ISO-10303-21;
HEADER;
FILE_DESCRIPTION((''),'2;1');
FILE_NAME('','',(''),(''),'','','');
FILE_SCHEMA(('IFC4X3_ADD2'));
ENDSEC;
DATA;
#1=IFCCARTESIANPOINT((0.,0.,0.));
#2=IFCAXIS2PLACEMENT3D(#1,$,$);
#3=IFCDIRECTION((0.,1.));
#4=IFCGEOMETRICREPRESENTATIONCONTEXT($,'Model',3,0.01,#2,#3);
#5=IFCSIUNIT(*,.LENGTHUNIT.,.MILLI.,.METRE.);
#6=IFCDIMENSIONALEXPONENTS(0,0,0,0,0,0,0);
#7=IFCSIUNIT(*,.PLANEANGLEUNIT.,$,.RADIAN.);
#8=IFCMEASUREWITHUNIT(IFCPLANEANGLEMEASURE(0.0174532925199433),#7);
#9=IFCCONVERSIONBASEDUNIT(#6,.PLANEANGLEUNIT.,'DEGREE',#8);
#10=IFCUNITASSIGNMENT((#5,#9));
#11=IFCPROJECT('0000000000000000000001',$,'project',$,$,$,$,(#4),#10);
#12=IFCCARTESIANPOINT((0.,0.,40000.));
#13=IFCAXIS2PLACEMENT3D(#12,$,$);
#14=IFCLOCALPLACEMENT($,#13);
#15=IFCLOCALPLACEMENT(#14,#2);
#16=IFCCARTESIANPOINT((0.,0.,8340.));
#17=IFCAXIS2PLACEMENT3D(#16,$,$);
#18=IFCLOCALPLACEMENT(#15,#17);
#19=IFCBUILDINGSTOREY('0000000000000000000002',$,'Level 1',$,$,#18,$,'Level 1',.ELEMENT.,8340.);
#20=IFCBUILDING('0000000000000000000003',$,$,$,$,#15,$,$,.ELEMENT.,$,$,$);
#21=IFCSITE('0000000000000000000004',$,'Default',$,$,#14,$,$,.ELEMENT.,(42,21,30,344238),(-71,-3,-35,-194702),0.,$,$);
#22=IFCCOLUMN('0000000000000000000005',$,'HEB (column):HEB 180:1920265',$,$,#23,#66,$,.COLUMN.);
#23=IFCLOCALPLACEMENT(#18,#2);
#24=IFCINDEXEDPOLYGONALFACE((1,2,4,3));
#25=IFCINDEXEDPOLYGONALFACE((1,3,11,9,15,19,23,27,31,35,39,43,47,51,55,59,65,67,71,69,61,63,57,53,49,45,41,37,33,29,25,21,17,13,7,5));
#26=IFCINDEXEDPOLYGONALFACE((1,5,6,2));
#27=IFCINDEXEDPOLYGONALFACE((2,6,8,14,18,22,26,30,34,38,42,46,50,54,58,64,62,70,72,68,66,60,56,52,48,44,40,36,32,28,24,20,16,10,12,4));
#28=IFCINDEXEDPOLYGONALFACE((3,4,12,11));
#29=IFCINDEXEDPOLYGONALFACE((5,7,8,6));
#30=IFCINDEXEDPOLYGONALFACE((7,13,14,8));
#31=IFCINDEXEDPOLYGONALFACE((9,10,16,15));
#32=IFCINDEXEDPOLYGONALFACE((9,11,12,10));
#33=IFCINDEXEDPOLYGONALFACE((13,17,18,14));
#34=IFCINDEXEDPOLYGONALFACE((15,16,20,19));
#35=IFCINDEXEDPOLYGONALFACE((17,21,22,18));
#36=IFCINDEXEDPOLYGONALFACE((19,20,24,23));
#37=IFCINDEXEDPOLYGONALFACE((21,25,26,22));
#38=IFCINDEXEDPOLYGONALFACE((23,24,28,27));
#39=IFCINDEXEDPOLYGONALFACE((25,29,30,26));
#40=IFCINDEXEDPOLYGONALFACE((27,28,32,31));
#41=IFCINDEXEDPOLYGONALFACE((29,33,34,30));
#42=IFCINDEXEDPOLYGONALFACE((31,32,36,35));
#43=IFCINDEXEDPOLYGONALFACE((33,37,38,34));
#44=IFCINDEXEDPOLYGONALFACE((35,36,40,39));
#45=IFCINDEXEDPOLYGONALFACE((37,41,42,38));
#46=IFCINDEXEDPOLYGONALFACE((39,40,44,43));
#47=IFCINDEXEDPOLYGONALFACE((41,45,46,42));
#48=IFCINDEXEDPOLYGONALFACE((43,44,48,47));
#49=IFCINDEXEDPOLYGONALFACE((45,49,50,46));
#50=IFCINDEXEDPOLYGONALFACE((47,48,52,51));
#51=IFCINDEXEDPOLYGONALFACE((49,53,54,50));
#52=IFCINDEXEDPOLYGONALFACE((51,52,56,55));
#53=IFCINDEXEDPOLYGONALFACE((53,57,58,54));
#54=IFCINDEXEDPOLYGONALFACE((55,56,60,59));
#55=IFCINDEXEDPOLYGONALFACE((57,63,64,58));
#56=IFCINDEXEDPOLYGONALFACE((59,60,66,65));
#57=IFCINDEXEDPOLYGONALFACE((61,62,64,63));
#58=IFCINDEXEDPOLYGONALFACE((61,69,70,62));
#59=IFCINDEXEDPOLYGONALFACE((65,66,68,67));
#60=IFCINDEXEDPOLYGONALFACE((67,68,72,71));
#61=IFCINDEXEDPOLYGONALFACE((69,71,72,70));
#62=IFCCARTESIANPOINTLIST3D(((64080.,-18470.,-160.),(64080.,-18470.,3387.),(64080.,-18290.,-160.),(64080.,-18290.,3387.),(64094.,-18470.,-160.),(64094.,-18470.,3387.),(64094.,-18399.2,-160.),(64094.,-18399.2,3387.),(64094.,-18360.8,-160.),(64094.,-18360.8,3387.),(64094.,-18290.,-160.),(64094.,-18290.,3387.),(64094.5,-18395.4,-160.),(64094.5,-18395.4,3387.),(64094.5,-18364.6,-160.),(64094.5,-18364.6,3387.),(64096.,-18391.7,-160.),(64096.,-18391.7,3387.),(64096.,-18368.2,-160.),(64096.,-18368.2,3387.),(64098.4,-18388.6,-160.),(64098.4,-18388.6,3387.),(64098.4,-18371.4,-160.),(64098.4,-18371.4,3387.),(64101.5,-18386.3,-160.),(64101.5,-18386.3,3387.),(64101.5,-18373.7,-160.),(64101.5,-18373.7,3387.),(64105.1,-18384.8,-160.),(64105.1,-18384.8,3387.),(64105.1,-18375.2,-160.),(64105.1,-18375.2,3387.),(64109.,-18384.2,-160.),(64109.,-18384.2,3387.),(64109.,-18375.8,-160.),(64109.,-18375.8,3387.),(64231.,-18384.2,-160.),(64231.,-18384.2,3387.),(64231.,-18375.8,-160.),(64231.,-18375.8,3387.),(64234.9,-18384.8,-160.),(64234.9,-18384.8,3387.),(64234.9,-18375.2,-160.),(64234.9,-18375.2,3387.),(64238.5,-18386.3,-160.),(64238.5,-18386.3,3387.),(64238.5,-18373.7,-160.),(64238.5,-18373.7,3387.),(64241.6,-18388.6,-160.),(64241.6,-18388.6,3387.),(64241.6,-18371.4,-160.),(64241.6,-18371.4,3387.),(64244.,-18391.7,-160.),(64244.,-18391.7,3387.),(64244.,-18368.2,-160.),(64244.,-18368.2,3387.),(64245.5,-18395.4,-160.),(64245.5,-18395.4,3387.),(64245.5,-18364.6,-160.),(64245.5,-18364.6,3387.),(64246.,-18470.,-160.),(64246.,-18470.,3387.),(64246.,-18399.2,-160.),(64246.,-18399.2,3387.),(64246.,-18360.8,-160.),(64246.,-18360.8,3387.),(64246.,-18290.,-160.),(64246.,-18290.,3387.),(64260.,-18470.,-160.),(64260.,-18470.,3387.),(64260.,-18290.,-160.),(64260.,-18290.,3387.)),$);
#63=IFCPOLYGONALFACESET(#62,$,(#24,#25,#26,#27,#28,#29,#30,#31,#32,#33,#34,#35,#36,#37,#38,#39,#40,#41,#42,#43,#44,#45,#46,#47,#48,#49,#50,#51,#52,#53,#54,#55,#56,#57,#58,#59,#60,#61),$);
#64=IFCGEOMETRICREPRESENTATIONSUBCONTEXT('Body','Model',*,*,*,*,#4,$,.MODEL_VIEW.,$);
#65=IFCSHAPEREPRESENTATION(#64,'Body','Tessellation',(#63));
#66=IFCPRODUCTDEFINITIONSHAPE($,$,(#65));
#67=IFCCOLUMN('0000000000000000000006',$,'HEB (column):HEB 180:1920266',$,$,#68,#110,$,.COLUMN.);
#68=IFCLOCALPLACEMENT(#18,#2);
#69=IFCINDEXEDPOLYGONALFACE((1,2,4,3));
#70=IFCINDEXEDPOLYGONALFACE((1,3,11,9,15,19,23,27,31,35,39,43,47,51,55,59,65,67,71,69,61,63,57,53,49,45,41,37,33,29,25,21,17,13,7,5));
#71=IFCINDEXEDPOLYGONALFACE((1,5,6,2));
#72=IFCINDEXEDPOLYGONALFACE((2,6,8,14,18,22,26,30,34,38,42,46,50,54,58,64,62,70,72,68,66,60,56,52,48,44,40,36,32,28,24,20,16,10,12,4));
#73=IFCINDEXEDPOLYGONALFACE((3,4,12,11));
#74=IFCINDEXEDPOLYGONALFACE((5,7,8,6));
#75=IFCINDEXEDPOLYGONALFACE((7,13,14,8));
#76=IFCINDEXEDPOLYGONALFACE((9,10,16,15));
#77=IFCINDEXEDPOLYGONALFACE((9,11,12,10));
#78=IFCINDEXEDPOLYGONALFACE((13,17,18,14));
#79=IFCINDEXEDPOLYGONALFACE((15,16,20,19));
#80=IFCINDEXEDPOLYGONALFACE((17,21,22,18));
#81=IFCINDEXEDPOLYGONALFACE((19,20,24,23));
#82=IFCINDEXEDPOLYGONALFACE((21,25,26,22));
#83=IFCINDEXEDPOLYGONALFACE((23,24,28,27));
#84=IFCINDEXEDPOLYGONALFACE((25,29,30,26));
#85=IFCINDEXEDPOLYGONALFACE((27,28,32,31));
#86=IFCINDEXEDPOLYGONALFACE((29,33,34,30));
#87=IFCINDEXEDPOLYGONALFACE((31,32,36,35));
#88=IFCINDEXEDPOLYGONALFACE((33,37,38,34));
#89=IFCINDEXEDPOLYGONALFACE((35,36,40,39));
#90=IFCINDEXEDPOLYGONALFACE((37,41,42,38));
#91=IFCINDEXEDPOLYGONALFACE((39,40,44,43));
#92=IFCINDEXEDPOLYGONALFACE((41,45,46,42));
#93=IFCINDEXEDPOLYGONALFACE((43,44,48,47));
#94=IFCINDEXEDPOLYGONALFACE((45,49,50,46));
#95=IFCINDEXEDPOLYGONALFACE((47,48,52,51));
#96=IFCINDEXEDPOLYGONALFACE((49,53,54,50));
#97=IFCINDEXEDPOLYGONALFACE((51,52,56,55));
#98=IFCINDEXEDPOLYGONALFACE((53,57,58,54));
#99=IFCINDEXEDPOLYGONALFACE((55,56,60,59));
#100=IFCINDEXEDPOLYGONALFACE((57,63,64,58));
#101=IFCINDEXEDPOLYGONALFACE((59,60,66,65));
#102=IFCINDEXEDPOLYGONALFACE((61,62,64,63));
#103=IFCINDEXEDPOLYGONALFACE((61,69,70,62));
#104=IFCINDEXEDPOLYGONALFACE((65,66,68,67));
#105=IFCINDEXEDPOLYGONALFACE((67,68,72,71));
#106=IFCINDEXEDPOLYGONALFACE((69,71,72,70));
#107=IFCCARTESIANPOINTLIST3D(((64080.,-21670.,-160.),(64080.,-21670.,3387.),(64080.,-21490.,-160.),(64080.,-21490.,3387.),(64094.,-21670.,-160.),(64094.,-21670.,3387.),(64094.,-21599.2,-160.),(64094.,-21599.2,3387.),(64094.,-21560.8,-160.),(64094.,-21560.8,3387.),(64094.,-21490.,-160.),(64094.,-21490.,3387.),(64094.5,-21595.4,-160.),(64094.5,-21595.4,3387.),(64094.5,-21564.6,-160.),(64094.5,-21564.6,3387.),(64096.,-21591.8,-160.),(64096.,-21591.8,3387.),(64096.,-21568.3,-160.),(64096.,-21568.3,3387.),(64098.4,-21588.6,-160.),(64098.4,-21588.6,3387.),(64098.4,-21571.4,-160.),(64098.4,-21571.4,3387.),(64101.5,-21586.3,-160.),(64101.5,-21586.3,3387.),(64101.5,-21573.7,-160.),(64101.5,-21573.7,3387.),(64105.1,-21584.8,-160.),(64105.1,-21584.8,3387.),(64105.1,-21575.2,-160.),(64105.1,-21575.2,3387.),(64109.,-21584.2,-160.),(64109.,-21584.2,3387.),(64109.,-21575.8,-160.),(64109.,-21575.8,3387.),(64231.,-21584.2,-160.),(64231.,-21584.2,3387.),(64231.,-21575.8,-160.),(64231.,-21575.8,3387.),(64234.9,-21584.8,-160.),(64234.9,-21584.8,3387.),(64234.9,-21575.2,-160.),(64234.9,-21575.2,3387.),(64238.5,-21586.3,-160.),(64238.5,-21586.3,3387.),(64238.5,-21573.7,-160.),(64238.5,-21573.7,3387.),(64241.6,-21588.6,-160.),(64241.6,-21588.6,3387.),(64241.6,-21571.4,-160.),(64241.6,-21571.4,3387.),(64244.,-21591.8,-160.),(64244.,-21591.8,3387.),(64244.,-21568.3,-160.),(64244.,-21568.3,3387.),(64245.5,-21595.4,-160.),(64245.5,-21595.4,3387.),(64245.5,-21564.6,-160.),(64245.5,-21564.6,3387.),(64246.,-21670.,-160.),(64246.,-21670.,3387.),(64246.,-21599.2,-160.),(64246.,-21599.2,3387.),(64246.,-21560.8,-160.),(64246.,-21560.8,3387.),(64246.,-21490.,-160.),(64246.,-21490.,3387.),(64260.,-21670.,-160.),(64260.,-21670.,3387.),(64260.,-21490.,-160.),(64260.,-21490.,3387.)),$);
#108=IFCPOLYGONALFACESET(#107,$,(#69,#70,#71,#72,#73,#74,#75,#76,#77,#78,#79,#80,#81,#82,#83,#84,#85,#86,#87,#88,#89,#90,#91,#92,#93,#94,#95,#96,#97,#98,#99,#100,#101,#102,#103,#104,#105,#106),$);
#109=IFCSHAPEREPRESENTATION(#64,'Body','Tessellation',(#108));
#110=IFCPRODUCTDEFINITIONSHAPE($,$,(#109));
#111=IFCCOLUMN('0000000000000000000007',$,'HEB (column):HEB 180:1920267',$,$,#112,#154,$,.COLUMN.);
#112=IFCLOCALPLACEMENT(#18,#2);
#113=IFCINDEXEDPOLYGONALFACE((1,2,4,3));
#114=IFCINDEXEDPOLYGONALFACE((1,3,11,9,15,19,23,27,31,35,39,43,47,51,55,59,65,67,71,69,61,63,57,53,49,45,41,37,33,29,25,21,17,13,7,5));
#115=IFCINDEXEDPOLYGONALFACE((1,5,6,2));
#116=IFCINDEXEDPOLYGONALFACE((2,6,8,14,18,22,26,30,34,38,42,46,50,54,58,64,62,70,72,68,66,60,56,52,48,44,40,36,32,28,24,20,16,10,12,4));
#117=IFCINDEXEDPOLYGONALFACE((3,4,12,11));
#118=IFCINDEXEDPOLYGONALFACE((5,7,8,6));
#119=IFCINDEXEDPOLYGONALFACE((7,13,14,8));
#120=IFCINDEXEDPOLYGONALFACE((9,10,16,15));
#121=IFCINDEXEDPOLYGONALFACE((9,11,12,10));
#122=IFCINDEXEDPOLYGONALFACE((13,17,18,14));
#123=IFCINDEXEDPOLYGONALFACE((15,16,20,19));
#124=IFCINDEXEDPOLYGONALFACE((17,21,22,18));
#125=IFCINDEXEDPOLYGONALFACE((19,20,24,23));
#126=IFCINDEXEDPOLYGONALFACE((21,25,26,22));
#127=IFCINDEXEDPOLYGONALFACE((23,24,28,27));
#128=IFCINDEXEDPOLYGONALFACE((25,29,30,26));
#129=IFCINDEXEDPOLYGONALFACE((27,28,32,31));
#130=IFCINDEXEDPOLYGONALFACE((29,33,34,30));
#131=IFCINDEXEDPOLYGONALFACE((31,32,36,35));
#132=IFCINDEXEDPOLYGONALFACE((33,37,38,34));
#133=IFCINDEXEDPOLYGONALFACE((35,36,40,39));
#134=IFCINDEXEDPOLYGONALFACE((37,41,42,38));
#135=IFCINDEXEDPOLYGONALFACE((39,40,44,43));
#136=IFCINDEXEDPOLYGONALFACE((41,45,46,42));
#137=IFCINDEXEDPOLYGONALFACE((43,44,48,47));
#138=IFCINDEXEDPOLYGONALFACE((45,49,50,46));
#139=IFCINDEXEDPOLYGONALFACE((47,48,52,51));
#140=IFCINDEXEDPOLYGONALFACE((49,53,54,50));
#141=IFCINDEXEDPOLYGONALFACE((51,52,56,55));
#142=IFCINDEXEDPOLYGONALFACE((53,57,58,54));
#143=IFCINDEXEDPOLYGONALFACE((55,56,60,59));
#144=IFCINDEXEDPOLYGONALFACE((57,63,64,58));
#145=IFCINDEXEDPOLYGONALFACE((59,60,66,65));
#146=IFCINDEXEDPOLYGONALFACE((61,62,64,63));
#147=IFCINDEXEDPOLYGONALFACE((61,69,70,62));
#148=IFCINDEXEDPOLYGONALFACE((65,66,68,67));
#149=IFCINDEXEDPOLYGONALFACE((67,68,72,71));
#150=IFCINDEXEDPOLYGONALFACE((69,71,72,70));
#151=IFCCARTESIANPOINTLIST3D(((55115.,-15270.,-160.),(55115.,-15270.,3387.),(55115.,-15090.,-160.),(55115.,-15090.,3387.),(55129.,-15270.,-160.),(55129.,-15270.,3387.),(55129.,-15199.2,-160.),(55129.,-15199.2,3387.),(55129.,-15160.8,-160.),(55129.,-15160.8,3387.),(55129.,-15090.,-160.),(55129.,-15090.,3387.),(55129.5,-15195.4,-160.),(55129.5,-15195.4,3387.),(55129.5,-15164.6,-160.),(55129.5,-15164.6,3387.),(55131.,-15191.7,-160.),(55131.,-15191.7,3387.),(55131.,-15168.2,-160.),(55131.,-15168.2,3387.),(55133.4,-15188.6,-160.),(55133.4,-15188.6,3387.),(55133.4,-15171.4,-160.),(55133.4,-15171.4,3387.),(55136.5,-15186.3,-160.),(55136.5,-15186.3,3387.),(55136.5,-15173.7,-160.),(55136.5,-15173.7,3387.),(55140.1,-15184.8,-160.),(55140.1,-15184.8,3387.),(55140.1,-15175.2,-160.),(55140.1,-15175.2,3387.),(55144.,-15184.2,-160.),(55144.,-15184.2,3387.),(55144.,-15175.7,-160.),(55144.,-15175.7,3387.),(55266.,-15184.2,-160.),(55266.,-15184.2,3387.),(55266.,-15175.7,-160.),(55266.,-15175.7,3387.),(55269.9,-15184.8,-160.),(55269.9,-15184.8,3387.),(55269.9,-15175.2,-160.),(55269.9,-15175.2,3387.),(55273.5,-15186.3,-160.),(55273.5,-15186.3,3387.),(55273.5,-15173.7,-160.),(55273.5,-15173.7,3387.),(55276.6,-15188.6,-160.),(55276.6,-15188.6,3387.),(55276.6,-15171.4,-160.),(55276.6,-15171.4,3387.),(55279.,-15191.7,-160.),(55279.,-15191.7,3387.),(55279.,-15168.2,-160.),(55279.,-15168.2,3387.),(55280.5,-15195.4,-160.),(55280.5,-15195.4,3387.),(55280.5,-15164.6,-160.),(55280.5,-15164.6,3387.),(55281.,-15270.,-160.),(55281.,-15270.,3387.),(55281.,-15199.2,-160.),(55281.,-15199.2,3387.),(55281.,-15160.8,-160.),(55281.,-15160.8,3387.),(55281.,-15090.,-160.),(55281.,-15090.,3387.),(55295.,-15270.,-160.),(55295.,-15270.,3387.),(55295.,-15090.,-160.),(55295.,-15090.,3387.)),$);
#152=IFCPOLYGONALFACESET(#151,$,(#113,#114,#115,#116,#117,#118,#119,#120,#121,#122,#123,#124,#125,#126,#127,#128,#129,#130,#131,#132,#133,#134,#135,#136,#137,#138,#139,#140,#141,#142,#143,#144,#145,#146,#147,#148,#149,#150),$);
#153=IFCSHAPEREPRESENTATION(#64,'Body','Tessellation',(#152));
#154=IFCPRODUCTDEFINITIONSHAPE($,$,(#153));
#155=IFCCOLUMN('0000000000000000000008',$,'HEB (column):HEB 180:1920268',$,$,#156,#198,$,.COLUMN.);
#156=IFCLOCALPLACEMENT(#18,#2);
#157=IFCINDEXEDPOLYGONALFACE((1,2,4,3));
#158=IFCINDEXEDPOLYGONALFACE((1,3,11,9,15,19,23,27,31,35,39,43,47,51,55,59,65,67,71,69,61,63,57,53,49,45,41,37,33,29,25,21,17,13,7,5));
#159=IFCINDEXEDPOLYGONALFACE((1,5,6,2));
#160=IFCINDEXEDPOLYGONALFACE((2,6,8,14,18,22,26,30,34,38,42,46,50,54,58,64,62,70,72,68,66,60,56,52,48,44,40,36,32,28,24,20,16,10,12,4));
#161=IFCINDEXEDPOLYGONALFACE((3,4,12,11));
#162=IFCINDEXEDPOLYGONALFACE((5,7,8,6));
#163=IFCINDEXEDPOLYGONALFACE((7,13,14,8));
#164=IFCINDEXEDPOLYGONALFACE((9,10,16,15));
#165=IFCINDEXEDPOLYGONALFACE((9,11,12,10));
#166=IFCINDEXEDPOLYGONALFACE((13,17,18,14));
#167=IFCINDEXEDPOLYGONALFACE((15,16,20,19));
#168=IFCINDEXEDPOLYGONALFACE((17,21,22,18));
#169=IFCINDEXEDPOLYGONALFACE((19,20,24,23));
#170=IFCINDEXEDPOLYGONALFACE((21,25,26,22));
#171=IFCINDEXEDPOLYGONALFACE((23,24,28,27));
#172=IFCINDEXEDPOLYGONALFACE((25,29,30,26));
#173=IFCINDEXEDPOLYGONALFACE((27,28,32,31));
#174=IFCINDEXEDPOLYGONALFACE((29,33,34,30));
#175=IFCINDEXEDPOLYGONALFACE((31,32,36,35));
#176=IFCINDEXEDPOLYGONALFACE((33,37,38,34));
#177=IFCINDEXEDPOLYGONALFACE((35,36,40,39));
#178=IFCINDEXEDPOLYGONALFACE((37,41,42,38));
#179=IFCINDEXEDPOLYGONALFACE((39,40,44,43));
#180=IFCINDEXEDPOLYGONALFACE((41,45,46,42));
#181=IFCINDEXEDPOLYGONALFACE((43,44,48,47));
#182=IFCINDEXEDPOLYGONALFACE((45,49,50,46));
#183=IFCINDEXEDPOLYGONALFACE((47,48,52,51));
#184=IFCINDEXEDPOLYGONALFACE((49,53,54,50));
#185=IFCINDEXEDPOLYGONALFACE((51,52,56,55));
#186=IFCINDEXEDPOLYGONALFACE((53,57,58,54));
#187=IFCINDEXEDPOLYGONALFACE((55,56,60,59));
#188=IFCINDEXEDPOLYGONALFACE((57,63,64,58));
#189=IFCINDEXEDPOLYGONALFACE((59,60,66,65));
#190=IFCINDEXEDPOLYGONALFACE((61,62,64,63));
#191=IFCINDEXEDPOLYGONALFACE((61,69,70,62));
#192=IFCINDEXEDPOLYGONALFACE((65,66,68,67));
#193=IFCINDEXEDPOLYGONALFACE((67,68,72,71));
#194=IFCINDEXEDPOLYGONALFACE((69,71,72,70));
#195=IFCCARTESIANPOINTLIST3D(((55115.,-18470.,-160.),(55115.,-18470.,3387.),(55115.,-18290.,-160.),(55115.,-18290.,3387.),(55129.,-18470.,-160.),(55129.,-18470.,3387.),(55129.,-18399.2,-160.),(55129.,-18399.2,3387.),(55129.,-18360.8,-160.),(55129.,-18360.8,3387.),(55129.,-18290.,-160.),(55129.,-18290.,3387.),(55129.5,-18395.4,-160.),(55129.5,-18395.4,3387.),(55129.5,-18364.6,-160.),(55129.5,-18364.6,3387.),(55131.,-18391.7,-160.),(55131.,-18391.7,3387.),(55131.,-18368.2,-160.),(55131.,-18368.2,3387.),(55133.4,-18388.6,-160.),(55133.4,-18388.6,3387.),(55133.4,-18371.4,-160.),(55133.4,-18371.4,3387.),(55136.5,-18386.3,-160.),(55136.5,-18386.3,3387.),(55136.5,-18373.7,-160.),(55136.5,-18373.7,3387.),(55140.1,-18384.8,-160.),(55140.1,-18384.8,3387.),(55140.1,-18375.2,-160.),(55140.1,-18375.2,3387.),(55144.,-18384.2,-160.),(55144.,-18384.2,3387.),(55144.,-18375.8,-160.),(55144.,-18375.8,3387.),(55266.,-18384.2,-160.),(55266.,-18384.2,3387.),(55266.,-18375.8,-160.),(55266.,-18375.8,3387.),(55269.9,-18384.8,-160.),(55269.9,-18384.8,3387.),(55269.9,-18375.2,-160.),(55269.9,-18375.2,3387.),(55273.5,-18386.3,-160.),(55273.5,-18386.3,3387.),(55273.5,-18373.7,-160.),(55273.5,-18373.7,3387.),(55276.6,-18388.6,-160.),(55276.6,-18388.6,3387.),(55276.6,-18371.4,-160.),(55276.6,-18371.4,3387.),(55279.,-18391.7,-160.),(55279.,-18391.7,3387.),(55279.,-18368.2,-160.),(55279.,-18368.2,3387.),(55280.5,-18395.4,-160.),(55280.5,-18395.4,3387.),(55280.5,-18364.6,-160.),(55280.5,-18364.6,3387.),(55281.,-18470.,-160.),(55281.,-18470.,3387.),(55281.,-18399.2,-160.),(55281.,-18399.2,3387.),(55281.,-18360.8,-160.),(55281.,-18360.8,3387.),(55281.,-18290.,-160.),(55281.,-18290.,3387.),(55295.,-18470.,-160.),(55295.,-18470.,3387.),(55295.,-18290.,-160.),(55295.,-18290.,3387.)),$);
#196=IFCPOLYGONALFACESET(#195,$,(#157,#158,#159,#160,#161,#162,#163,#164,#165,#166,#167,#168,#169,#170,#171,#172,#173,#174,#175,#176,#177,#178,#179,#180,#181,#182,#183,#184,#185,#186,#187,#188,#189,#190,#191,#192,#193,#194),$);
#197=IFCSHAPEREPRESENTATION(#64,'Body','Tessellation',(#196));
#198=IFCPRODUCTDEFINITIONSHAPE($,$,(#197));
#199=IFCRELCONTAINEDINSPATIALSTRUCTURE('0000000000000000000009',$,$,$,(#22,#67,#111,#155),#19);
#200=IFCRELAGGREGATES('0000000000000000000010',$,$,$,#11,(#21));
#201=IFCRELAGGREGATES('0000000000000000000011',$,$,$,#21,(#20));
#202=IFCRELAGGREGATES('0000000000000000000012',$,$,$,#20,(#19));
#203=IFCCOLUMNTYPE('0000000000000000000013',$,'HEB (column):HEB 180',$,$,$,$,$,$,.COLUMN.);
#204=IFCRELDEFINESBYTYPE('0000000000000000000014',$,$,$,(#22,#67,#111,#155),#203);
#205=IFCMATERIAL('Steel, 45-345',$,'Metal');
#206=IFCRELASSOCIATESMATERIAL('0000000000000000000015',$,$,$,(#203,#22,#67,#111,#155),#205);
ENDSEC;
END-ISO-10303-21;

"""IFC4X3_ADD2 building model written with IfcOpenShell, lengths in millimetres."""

from ifc_helpers import new_model, entity, si_unit, converted_unit, direction, frame, origin, origin_2d_with_axis, place, context, subcontext, project, spatial, i_section, extrude, source, transform, mapped, material, material_profile, profile_set, profile_usage, type_object, type_shapes, element, save


model = new_model("IFC4X3_ADD2")

# Units and contexts
model_context = context("Model", 3, precision=0.01, world=origin(), true_north=direction((0.0, 1.0)))
body_context = subcontext(model_context, "Body", "Model", "MODEL_VIEW")
ifc_project = project(units=[si_unit("LENGTHUNIT", "METRE", prefix="MILLI"), converted_unit("PLANEANGLEUNIT", "DEGREE", entity("IfcPlaneAngleMeasure", 0.0174532925199433), si_unit("PLANEANGLEUNIT", "RADIAN"), dimensions=[0, 0, 0, 0, 0, 0, 0])], contexts=[model_context])

# Site, building, storey
site_placement = place(None, frame((0.0, 0.0, 40000.0)))
site = spatial("IfcSite", under=ifc_project, at=site_placement, Name="Default", CompositionType="ELEMENT", RefLatitude=(42, 21, 30, 344238), RefLongitude=(-71, -3, -35, -194702), RefElevation=0.0)
building_placement = place(site_placement, origin())
building = spatial("IfcBuilding", under=site, at=building_placement, CompositionType="ELEMENT")
storey_placement = place(building_placement, frame((0.0, 0.0, 8340.0)))
storey = spatial("IfcBuildingStorey", under=building, at=storey_placement, Name="Level 1", LongName="Level 1", CompositionType="ELEMENT", Elevation=8340.0)

# Columns
ifc_material_1 = material(Name="Steel, 45-345", Category="Metal")
ifc_material_profile_1 = material_profile(ifc_material_1, i_section(OverallWidth=180.0, OverallDepth=180.0, WebThickness=8.5, FlangeThickness=14.0, FilletRadius=15.0, at=origin_2d_with_axis()), Name="HEB 180")
ifc_profile_set_1 = profile_set([ifc_material_profile_1], Name="HEB 180")
ifc_profile_usage_1 = profile_usage(ifc_profile_set_1)
column_type_1 = type_object("IfcColumnType", Name="HEB (column):HEB 180", PredefinedType="COLUMN", material=ifc_profile_set_1)
shared_shape_1 = source(origin(), body_context, "Body", "SweptSolid", [
    extrude(i_section(OverallWidth=180.0, OverallDepth=180.0, WebThickness=8.5, FlangeThickness=14.0, FilletRadius=15.0, at=origin_2d_with_axis()), frame((0.0, 0.0, 8180.0), z_axis=(0.0, 0.0, 1.0), x_axis=(-1.0, 0.0, 0.0)), (0.0, 0.0, 1.0), 3547.0),
])
type_shapes(column_type_1, [shared_shape_1])
for number, where, z_axis, x_axis, name in (
    (1, (64170.0, -18380.0, -8340.0), (0.0, 0.0, 1.0), (0.0, -1.0, 0.0), "HEB (column):HEB 180:1920265"),
    (2, (64170.0, -21580.0, -8340.0), (0.0, 0.0, 1.0), (0.0, -1.0, 0.0), "HEB (column):HEB 180:1920266"),
    (3, (55205.0, -15180.0, -8340.0), (0.0, 0.0, 1.0), (0.0, -1.0, 0.0), "HEB (column):HEB 180:1920267"),
    (4, (55205.0, -18380.0, -8340.0), (0.0, 0.0, 1.0), (0.0, -1.0, 0.0), "HEB (column):HEB 180:1920268"),
):
    element("IfcColumn", number, at=place(storey_placement, frame(where, z_axis=z_axis, x_axis=x_axis)), inside=storey, type_object=column_type_1, material=ifc_profile_usage_1, Name=name, PredefinedType="COLUMN", context=body_context, shape_type="MappedRepresentation", body=[
        mapped(shared_shape_1, transform((0.0, 0.0, 0.0), scale=1.0)),
    ])

save(model, "model.ifc")
